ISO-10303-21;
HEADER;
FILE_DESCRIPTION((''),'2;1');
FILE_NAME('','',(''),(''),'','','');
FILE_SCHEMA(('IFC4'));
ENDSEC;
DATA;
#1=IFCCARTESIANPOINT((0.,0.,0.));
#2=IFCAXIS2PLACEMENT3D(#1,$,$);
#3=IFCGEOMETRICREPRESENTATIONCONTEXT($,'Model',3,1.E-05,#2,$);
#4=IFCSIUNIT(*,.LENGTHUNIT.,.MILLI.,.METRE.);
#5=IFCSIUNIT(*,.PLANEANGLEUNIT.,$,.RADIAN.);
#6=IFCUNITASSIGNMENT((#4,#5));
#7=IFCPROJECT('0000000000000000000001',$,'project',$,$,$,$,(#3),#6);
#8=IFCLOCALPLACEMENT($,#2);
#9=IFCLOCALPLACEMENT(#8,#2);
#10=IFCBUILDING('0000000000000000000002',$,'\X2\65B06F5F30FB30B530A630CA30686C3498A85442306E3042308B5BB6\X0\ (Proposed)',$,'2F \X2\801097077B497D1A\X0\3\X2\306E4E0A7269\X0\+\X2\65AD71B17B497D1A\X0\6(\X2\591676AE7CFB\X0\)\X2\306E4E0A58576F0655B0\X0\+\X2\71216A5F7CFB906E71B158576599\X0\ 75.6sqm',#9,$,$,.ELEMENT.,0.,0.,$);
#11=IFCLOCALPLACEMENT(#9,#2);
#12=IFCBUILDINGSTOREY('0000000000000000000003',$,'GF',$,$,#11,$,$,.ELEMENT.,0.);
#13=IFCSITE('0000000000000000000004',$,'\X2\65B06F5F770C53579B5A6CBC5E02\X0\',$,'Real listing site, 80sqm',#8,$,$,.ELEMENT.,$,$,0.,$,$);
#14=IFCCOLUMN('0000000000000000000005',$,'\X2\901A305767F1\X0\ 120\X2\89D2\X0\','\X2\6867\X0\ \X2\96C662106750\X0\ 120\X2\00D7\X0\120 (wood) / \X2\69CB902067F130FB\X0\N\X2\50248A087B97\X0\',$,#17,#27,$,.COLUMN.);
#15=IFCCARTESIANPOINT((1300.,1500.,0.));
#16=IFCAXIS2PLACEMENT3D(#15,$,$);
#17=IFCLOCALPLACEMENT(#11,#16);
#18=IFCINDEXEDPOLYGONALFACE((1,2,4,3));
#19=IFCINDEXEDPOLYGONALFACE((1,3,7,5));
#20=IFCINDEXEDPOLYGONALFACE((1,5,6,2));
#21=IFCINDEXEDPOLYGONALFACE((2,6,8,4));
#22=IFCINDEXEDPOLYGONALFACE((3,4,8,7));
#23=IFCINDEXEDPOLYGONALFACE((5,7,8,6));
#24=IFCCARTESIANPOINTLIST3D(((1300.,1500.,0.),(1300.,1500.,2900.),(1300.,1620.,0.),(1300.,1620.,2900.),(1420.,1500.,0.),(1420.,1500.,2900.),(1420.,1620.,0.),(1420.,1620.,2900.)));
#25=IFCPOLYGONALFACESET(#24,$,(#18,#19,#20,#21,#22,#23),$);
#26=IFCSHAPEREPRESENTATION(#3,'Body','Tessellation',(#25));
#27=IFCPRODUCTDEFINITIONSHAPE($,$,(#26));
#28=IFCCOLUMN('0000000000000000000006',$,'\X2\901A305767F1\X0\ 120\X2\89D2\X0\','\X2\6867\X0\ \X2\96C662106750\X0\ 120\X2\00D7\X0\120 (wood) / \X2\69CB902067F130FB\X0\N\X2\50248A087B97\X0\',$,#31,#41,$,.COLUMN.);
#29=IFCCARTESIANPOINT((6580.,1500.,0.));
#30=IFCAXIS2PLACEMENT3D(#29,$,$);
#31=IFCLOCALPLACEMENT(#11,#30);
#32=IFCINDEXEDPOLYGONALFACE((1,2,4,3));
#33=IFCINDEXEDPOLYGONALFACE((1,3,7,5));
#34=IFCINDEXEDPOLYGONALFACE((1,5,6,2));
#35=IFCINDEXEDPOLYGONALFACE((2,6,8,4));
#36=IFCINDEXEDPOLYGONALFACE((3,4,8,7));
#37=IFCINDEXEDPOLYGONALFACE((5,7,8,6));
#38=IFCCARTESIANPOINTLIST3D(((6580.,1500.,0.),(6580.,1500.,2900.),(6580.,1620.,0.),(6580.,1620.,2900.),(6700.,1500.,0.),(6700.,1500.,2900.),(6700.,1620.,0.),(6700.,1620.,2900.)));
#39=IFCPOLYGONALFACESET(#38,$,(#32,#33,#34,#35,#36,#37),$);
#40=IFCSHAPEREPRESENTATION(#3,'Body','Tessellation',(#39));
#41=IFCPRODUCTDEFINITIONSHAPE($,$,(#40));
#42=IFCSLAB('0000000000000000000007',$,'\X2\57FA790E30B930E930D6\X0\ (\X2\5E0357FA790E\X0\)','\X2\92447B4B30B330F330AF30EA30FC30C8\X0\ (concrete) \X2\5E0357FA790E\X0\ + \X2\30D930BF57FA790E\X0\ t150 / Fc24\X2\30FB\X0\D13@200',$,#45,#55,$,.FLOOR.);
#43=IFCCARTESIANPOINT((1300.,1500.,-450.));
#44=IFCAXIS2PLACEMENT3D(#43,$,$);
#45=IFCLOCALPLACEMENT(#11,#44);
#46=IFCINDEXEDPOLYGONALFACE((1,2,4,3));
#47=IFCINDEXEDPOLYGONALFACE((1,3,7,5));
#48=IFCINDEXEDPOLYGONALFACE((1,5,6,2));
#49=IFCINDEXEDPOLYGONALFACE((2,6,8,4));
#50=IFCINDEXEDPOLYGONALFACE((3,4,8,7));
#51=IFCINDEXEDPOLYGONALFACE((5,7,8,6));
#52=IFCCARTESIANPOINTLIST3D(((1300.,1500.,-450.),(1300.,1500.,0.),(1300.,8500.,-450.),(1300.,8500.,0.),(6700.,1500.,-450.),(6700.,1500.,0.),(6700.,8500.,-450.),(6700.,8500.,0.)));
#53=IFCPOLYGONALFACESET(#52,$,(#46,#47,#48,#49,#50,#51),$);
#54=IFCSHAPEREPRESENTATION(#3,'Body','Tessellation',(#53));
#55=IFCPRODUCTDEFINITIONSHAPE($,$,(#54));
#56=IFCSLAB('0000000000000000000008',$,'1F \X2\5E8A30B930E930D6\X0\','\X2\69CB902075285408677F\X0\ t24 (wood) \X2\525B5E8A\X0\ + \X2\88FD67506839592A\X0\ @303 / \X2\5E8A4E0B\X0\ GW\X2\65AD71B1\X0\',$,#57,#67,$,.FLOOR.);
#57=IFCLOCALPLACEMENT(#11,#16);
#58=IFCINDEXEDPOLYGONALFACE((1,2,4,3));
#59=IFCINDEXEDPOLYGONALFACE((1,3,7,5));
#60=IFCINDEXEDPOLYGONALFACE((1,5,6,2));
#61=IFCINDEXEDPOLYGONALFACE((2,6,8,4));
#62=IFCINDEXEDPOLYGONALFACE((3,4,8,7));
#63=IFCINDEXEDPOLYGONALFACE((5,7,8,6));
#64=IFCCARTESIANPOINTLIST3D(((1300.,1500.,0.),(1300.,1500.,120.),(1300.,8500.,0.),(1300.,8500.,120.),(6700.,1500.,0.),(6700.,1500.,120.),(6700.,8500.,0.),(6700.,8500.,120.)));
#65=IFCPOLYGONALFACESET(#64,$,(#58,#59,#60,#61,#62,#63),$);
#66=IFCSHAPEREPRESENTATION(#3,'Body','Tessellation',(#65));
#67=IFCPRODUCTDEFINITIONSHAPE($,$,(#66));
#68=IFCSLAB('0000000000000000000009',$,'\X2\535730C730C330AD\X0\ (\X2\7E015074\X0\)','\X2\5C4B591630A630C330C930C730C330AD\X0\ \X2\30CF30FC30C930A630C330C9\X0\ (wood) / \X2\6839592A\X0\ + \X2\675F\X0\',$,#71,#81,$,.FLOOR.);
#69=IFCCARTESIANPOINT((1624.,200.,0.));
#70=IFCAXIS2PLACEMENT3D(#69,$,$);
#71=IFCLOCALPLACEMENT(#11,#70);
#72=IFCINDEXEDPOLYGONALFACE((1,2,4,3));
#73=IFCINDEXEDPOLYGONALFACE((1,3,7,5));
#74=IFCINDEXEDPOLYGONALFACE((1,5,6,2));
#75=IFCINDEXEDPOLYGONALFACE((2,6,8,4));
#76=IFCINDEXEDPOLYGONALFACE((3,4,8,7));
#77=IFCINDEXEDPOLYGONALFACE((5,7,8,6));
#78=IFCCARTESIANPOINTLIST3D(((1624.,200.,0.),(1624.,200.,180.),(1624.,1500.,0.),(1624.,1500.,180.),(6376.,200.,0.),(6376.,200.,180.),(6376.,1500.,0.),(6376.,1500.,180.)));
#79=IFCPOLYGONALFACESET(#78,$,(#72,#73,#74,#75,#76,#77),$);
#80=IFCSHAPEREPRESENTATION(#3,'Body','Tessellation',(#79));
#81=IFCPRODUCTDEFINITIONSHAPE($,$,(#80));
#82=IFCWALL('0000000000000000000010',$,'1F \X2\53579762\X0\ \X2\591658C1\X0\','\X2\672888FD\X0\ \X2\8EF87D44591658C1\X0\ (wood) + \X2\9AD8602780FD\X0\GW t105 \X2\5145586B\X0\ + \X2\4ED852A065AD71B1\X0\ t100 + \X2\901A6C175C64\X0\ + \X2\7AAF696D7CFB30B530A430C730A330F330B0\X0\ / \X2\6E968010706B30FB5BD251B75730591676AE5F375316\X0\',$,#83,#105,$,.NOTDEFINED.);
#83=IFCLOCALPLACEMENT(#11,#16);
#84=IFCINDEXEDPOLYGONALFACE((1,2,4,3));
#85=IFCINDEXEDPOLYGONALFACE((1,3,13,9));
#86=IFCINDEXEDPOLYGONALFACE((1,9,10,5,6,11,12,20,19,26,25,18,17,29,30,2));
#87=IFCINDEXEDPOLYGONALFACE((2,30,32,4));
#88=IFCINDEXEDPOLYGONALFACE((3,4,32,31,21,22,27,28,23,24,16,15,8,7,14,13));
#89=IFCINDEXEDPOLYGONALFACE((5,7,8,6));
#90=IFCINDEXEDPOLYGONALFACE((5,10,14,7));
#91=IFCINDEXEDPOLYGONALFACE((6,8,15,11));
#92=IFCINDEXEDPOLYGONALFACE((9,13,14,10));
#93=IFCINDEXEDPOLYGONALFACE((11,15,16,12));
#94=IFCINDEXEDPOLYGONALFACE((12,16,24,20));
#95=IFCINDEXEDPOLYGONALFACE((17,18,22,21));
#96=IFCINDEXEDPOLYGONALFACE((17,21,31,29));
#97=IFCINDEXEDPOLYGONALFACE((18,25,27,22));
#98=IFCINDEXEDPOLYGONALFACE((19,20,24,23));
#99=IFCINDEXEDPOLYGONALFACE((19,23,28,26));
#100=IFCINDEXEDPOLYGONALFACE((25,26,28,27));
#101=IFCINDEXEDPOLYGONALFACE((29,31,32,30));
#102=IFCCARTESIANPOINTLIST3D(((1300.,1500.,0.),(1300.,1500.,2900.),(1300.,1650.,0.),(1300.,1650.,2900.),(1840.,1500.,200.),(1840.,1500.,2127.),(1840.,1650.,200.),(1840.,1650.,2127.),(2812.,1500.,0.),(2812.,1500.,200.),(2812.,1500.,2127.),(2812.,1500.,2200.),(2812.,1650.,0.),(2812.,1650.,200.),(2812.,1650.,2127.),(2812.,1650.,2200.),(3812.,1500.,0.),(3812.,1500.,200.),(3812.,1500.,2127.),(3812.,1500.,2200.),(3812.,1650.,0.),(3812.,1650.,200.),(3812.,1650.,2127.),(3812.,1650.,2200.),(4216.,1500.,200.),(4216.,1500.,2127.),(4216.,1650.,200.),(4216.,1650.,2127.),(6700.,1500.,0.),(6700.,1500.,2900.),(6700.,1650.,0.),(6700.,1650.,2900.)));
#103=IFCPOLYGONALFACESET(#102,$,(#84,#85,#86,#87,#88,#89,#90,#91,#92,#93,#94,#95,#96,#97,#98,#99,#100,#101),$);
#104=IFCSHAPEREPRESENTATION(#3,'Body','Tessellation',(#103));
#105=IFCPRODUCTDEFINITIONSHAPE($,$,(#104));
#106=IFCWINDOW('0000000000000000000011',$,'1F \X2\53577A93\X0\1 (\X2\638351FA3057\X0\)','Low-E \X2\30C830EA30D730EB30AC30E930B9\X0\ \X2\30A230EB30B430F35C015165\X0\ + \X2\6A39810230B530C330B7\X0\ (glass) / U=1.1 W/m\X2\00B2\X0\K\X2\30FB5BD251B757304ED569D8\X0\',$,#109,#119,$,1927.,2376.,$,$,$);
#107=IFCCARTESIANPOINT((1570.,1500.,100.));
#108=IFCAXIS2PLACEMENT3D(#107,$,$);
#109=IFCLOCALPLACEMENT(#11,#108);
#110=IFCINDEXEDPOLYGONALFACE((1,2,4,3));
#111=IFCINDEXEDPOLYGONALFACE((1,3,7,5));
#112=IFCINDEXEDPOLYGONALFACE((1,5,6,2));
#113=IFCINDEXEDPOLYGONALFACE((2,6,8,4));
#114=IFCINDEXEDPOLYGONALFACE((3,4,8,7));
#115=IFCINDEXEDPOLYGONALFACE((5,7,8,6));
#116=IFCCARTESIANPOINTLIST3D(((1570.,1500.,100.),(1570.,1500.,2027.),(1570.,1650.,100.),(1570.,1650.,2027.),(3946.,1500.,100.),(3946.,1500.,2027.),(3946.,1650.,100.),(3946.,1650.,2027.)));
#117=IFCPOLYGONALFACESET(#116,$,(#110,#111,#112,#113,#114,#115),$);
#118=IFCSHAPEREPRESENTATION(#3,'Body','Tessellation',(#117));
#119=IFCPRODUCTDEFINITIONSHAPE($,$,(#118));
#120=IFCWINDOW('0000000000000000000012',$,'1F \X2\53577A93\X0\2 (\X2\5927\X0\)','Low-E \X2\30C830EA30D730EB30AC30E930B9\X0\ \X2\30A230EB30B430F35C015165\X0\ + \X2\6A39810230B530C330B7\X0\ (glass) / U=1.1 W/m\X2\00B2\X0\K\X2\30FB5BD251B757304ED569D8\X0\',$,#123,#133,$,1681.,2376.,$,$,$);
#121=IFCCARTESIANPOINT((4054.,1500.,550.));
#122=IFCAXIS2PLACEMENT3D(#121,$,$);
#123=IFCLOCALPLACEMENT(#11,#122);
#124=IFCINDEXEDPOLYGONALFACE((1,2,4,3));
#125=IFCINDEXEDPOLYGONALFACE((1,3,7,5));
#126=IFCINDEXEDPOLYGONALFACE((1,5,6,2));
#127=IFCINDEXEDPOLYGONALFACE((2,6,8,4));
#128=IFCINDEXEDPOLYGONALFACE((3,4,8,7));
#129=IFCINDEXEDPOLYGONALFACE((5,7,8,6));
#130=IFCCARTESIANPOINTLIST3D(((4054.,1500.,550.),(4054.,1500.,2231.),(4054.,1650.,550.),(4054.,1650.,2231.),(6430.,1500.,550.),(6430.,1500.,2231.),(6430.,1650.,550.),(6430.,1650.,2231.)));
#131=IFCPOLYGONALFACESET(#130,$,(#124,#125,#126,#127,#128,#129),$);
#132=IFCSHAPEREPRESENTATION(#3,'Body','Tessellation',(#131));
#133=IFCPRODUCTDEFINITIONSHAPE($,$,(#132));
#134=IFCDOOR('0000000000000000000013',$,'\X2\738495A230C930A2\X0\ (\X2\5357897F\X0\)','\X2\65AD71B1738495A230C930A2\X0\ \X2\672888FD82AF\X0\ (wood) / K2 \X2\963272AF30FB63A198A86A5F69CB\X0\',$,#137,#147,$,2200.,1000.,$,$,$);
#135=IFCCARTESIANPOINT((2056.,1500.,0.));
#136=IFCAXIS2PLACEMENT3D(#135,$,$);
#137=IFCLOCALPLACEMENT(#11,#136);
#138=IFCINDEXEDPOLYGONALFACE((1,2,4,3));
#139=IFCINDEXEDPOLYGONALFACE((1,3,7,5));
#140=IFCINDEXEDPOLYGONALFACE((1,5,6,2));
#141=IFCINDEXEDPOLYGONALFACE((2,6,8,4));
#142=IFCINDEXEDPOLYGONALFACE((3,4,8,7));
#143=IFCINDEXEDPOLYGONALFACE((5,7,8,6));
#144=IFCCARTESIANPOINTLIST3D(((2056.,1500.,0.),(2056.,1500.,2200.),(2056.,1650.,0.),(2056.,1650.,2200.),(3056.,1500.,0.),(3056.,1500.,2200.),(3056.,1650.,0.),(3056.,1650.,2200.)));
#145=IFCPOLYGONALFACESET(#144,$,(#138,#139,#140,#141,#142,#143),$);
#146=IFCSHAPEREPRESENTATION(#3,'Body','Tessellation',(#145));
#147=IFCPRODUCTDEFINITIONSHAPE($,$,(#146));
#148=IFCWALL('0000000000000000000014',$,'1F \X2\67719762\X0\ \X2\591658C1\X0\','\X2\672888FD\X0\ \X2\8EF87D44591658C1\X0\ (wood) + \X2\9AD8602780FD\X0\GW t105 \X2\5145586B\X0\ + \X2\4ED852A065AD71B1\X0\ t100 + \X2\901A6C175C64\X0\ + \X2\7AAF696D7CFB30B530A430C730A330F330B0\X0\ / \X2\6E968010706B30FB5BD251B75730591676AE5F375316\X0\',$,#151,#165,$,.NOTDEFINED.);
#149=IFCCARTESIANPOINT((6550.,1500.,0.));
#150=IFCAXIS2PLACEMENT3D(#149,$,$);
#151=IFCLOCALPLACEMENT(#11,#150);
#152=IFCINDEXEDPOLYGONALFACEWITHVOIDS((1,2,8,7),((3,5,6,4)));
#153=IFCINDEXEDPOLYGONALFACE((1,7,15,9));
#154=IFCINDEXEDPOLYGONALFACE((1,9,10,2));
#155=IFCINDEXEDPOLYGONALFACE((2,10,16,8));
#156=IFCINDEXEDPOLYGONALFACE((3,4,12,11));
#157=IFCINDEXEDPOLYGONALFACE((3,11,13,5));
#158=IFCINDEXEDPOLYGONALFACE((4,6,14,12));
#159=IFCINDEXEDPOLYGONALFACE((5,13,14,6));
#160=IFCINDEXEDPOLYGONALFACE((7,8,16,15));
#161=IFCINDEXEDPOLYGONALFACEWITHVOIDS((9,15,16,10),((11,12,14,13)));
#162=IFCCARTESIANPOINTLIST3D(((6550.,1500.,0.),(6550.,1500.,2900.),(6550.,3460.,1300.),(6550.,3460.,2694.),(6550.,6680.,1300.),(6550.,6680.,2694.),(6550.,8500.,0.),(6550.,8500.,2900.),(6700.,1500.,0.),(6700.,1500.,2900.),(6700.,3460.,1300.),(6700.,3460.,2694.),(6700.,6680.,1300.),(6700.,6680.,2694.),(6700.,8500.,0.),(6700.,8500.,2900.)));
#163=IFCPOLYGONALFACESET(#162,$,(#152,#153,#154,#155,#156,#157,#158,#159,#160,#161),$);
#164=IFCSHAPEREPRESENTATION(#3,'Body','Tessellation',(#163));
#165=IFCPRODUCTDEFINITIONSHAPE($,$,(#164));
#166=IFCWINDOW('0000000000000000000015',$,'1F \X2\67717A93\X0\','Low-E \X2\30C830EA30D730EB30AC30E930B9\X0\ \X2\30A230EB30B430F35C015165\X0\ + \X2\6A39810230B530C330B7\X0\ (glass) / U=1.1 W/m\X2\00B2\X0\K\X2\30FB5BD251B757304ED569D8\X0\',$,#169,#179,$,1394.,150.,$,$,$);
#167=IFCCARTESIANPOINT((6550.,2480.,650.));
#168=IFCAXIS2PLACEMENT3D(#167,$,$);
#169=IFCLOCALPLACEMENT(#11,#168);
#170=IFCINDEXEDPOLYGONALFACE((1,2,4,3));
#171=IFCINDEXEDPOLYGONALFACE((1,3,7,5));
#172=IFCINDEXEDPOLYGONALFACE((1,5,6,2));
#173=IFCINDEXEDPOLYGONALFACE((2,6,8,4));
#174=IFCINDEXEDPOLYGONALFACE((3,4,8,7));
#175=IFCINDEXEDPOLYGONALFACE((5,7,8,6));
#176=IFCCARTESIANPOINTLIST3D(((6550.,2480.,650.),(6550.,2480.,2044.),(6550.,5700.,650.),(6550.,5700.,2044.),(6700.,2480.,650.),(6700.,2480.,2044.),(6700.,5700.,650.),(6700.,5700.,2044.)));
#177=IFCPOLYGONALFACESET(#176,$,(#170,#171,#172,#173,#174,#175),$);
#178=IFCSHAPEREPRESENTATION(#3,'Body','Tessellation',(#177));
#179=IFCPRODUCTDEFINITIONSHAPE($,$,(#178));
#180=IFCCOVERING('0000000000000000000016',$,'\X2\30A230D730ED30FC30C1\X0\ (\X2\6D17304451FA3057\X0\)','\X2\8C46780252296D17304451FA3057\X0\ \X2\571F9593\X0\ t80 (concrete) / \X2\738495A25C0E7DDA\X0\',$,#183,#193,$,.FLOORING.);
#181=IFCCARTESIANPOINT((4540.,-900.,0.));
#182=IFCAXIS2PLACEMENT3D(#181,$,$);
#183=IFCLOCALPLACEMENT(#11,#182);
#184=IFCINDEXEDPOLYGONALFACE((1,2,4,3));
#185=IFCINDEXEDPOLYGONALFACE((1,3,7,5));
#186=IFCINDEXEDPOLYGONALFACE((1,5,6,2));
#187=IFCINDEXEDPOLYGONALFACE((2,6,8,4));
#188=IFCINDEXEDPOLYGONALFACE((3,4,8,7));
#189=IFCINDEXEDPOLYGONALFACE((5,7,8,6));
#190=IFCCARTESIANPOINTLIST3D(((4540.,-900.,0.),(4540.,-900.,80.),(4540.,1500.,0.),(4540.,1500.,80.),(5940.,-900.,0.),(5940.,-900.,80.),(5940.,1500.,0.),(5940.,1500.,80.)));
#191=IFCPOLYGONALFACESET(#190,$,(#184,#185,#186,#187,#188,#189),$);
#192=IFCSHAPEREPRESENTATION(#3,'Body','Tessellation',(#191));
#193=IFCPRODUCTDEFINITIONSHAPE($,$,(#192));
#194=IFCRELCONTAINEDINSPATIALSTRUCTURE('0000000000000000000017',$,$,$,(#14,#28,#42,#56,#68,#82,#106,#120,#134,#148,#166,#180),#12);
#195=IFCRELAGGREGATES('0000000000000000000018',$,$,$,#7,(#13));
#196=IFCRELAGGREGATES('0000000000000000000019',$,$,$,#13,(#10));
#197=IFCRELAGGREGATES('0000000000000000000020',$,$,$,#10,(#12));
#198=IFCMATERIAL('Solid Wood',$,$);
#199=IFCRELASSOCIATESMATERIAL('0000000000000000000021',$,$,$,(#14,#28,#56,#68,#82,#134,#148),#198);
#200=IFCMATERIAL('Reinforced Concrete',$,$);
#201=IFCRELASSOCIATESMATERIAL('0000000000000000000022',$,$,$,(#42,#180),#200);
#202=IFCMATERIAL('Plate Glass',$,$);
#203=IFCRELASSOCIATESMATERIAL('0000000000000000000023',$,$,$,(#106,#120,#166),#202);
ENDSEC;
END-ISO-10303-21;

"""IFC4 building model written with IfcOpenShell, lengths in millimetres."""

from ifc_helpers import new_model, si_unit, frame, frame_2d, origin, place, context, project, spatial, rectangle, extrude, material, element, fill, save


model = new_model("IFC4")

# Units and contexts
model_context = context("Model", 3, precision=1e-05, world=origin())
ifc_project = project(units=[si_unit("LENGTHUNIT", "METRE", prefix="MILLI"), si_unit("PLANEANGLEUNIT", "RADIAN")], contexts=[model_context])

# Site, building, storey
site_placement = place(None, origin())
site = spatial("IfcSite", under=ifc_project, at=site_placement, Name="新潟県南魚沼市", ObjectType="Real listing site, 80sqm", CompositionType="ELEMENT", RefElevation=0.0)
building_placement = place(site_placement, origin())
building = spatial("IfcBuilding", under=site, at=building_placement, Name="新潟・サウナと水風呂のある家 (Proposed)", ObjectType="2F 耐震等級3の上物+断熱等級6(外皮系)の上塗漆喰+無機系遮熱塗料 75.6sqm", CompositionType="ELEMENT", ElevationOfRefHeight=0.0, ElevationOfTerrain=0.0)
storey_placement = place(building_placement, origin())
storey = spatial("IfcBuildingStorey", under=building, at=storey_placement, Name="GF", CompositionType="ELEMENT", Elevation=0.0)

# Columns
ifc_material_1 = material(Name="Solid Wood")
column_1_placement = place(storey_placement, frame((1300.0, 1500.0, 0.0)))
element("IfcColumn", 1, at=column_1_placement, inside=storey, material=ifc_material_1, Name="通し柱 120角", Description="桧 集成材 120×120 (wood) / 構造柱・N値計算", PredefinedType="COLUMN", context=model_context, shape_type="SweptSolid", body=[
    extrude(rectangle(XDim=120.0, YDim=120.0, at=frame_2d((60.0, 60.0))), frame((1300.0, 1500.0, 0.0)), (0.0, 0.0, 1.0), 2900.0),
])
column_2_placement = place(storey_placement, frame((6580.0, 1500.0, 0.0)))
element("IfcColumn", 2, at=column_2_placement, inside=storey, material=ifc_material_1, Name="通し柱 120角", Description="桧 集成材 120×120 (wood) / 構造柱・N値計算", PredefinedType="COLUMN", context=model_context, shape_type="SweptSolid", body=[
    extrude(rectangle(XDim=120.0, YDim=120.0, at=frame_2d((60.0, 60.0))), frame((6580.0, 1500.0, 0.0)), (0.0, 0.0, 1.0), 2900.0),
])

# Slabs
ifc_material_2 = material(Name="Reinforced Concrete")
slab_1_placement = place(storey_placement, frame((1300.0, 1500.0, -450.0)))
element("IfcSlab", 3, at=slab_1_placement, inside=storey, material=ifc_material_2, Name="基礎スラブ (布基礎)", Description="鉄筋コンクリート (concrete) 布基礎 + ベタ基礎 t150 / Fc24・D13@200", PredefinedType="FLOOR", context=model_context, shape_type="SweptSolid", body=[
    extrude(rectangle(XDim=5400.0, YDim=7000.0, at=frame_2d((2700.0, 3500.0))), frame((1300.0, 1500.0, -450.0)), (0.0, 0.0, 1.0), 450.0),
])
slab_2_placement = place(storey_placement, frame((1300.0, 1500.0, 0.0)))
element("IfcSlab", 4, at=slab_2_placement, inside=storey, material=ifc_material_1, Name="1F 床スラブ", Description="構造用合板 t24 (wood) 剛床 + 製材根太 @303 / 床下 GW断熱", PredefinedType="FLOOR", context=model_context, shape_type="SweptSolid", body=[
    extrude(rectangle(XDim=5400.0, YDim=7000.0, at=frame_2d((2700.0, 3500.0))), frame((1300.0, 1500.0, 0.0)), (0.0, 0.0, 1.0), 120.0),
])
slab_3_placement = place(storey_placement, frame((1624.0, 200.0, 0.0)))
element("IfcSlab", 5, at=slab_3_placement, inside=storey, material=ifc_material_1, Name="南デッキ (縁側)", Description="屋外ウッドデッキ ハードウッド (wood) / 根太 + 束", PredefinedType="FLOOR", context=model_context, shape_type="SweptSolid", body=[
    extrude(rectangle(XDim=4752.0, YDim=1300.0, at=frame_2d((2376.0, 650.0))), frame((1624.0, 200.0, 0.0)), (0.0, 0.0, 1.0), 180.0),
])

# Wall, openings, windows, door
wall_1_placement = place(storey_placement, frame((1300.0, 1500.0, 0.0)))
wall_1 = element("IfcWall", 6, at=wall_1_placement, inside=storey, material=ifc_material_1, Name="1F 南面 外壁", Description="木製 軸組外壁 (wood) + 高性能GW t105 充填 + 付加断熱 t100 + 通気層 + 窯業系サイディング / 準耐火・寒冷地外皮強化", PredefinedType="NOTDEFINED", context=model_context, shape_type="SweptSolid", body=[
    extrude(rectangle(XDim=5400.0, YDim=150.0, at=frame_2d((2700.0, 75.0))), frame((1300.0, 1500.0, 0.0)), (0.0, 0.0, 1.0), 2900.0),
])
opening_1_placement = place(storey_placement, frame((1570.0, 1500.0, 100.0)))
opening_1 = element("IfcOpeningElement", 7, at=opening_1_placement, cuts=wall_1, PredefinedType="NOTDEFINED", context=model_context, shape_type="SweptSolid", body=[
    extrude(rectangle(XDim=2376.0, YDim=150.0, at=frame_2d((1188.0, 75.0))), frame((1570.0, 1500.0, 100.0)), (0.0, 0.0, 1.0), 1927.0),
])
opening_2_placement = place(storey_placement, frame((4054.0, 1500.0, 550.0)))
opening_2 = element("IfcOpeningElement", 8, at=opening_2_placement, cuts=wall_1, PredefinedType="NOTDEFINED", context=model_context, shape_type="SweptSolid", body=[
    extrude(rectangle(XDim=2376.0, YDim=150.0, at=frame_2d((1188.0, 75.0))), frame((4054.0, 1500.0, 550.0)), (0.0, 0.0, 1.0), 1681.0),
])
opening_3_placement = place(storey_placement, frame((2056.0, 1500.0, 0.0)))
opening_3 = element("IfcOpeningElement", 9, at=opening_3_placement, cuts=wall_1, PredefinedType="NOTDEFINED", context=model_context, shape_type="SweptSolid", body=[
    extrude(rectangle(XDim=1000.0, YDim=150.0, at=frame_2d((500.0, 75.0))), frame((2056.0, 1500.0, 0.0)), (0.0, 0.0, 1.0), 2200.0),
])
ifc_material_3 = material(Name="Plate Glass")
window_1_placement = place(storey_placement, frame((1570.0, 1500.0, 100.0)))
window_1 = element("IfcWindow", 10, at=window_1_placement, inside=storey, material=ifc_material_3, Name="1F 南窓1 (掃出し)", Description="Low-E トリプルガラス アルゴン封入 + 樹脂サッシ (glass) / U=1.1 W/m²K・寒冷地仕様", OverallHeight=1927.0, OverallWidth=2376.0, context=model_context, shape_type="SweptSolid", body=[
    extrude(rectangle(XDim=2376.0, YDim=150.0, at=frame_2d((1188.0, 75.0))), frame((1570.0, 1500.0, 100.0)), (0.0, 0.0, 1.0), 1927.0),
])
fill(opening_1, window_1)
window_2_placement = place(storey_placement, frame((4054.0, 1500.0, 550.0)))
window_2 = element("IfcWindow", 11, at=window_2_placement, inside=storey, material=ifc_material_3, Name="1F 南窓2 (大)", Description="Low-E トリプルガラス アルゴン封入 + 樹脂サッシ (glass) / U=1.1 W/m²K・寒冷地仕様", OverallHeight=1681.0, OverallWidth=2376.0, context=model_context, shape_type="SweptSolid", body=[
    extrude(rectangle(XDim=2376.0, YDim=150.0, at=frame_2d((1188.0, 75.0))), frame((4054.0, 1500.0, 550.0)), (0.0, 0.0, 1.0), 1681.0),
])
fill(opening_2, window_2)
door_placement = place(storey_placement, frame((2056.0, 1500.0, 0.0)))
door = element("IfcDoor", 12, at=door_placement, inside=storey, material=ifc_material_1, Name="玄関ドア (南西)", Description="断熱玄関ドア 木製芯 (wood) / K2 防犯・採風機構", OverallHeight=2200.0, OverallWidth=1000.0, context=model_context, shape_type="SweptSolid", body=[
    extrude(rectangle(XDim=1000.0, YDim=150.0, at=frame_2d((500.0, 75.0))), frame((2056.0, 1500.0, 0.0)), (0.0, 0.0, 1.0), 2200.0),
])
fill(opening_3, door)

# Wall, opening, window
wall_2_placement = place(storey_placement, frame((6550.0, 1500.0, 0.0)))
wall_2 = element("IfcWall", 13, at=wall_2_placement, inside=storey, material=ifc_material_1, Name="1F 東面 外壁", Description="木製 軸組外壁 (wood) + 高性能GW t105 充填 + 付加断熱 t100 + 通気層 + 窯業系サイディング / 準耐火・寒冷地外皮強化", PredefinedType="NOTDEFINED", context=model_context, shape_type="SweptSolid", body=[
    extrude(rectangle(XDim=150.0, YDim=7000.0, at=frame_2d((75.0, 3500.0))), frame((6550.0, 1500.0, 0.0)), (0.0, 0.0, 1.0), 2900.0),
])
opening_4_placement = place(storey_placement, frame((6550.0, 2480.0, 650.0)))
opening_4 = element("IfcOpeningElement", 14, at=opening_4_placement, cuts=wall_2, PredefinedType="NOTDEFINED", context=model_context, shape_type="SweptSolid", body=[
    extrude(rectangle(XDim=150.0, YDim=3220.0, at=frame_2d((75.0, 1610.0))), frame((6550.0, 2480.0, 650.0)), (0.0, 0.0, 1.0), 1394.0),
])
window_3_placement = place(storey_placement, frame((6550.0, 2480.0, 650.0)))
window_3 = element("IfcWindow", 15, at=window_3_placement, inside=storey, material=ifc_material_3, Name="1F 東窓", Description="Low-E トリプルガラス アルゴン封入 + 樹脂サッシ (glass) / U=1.1 W/m²K・寒冷地仕様", OverallHeight=1394.0, OverallWidth=150.0, context=model_context, shape_type="SweptSolid", body=[
    extrude(rectangle(XDim=150.0, YDim=3220.0, at=frame_2d((75.0, 1610.0))), frame((6550.0, 2480.0, 650.0)), (0.0, 0.0, 1.0), 1394.0),
])
fill(opening_4, window_3)

# Covering
covering_1_placement = place(storey_placement, frame((4540.0, -900.0, 0.0)))
element("IfcCovering", 16, at=covering_1_placement, inside=storey, material=ifc_material_2, Name="アプローチ (洗い出し)", Description="豆砂利洗い出し 土間 t80 (concrete) / 玄関導線", PredefinedType="FLOORING", context=model_context, shape_type="SweptSolid", body=[
    extrude(rectangle(XDim=1400.0, YDim=2400.0, at=frame_2d((700.0, 1200.0))), frame((4540.0, -900.0, 0.0)), (0.0, 0.0, 1.0), 80.0),
])

save(model, "model.ifc")
